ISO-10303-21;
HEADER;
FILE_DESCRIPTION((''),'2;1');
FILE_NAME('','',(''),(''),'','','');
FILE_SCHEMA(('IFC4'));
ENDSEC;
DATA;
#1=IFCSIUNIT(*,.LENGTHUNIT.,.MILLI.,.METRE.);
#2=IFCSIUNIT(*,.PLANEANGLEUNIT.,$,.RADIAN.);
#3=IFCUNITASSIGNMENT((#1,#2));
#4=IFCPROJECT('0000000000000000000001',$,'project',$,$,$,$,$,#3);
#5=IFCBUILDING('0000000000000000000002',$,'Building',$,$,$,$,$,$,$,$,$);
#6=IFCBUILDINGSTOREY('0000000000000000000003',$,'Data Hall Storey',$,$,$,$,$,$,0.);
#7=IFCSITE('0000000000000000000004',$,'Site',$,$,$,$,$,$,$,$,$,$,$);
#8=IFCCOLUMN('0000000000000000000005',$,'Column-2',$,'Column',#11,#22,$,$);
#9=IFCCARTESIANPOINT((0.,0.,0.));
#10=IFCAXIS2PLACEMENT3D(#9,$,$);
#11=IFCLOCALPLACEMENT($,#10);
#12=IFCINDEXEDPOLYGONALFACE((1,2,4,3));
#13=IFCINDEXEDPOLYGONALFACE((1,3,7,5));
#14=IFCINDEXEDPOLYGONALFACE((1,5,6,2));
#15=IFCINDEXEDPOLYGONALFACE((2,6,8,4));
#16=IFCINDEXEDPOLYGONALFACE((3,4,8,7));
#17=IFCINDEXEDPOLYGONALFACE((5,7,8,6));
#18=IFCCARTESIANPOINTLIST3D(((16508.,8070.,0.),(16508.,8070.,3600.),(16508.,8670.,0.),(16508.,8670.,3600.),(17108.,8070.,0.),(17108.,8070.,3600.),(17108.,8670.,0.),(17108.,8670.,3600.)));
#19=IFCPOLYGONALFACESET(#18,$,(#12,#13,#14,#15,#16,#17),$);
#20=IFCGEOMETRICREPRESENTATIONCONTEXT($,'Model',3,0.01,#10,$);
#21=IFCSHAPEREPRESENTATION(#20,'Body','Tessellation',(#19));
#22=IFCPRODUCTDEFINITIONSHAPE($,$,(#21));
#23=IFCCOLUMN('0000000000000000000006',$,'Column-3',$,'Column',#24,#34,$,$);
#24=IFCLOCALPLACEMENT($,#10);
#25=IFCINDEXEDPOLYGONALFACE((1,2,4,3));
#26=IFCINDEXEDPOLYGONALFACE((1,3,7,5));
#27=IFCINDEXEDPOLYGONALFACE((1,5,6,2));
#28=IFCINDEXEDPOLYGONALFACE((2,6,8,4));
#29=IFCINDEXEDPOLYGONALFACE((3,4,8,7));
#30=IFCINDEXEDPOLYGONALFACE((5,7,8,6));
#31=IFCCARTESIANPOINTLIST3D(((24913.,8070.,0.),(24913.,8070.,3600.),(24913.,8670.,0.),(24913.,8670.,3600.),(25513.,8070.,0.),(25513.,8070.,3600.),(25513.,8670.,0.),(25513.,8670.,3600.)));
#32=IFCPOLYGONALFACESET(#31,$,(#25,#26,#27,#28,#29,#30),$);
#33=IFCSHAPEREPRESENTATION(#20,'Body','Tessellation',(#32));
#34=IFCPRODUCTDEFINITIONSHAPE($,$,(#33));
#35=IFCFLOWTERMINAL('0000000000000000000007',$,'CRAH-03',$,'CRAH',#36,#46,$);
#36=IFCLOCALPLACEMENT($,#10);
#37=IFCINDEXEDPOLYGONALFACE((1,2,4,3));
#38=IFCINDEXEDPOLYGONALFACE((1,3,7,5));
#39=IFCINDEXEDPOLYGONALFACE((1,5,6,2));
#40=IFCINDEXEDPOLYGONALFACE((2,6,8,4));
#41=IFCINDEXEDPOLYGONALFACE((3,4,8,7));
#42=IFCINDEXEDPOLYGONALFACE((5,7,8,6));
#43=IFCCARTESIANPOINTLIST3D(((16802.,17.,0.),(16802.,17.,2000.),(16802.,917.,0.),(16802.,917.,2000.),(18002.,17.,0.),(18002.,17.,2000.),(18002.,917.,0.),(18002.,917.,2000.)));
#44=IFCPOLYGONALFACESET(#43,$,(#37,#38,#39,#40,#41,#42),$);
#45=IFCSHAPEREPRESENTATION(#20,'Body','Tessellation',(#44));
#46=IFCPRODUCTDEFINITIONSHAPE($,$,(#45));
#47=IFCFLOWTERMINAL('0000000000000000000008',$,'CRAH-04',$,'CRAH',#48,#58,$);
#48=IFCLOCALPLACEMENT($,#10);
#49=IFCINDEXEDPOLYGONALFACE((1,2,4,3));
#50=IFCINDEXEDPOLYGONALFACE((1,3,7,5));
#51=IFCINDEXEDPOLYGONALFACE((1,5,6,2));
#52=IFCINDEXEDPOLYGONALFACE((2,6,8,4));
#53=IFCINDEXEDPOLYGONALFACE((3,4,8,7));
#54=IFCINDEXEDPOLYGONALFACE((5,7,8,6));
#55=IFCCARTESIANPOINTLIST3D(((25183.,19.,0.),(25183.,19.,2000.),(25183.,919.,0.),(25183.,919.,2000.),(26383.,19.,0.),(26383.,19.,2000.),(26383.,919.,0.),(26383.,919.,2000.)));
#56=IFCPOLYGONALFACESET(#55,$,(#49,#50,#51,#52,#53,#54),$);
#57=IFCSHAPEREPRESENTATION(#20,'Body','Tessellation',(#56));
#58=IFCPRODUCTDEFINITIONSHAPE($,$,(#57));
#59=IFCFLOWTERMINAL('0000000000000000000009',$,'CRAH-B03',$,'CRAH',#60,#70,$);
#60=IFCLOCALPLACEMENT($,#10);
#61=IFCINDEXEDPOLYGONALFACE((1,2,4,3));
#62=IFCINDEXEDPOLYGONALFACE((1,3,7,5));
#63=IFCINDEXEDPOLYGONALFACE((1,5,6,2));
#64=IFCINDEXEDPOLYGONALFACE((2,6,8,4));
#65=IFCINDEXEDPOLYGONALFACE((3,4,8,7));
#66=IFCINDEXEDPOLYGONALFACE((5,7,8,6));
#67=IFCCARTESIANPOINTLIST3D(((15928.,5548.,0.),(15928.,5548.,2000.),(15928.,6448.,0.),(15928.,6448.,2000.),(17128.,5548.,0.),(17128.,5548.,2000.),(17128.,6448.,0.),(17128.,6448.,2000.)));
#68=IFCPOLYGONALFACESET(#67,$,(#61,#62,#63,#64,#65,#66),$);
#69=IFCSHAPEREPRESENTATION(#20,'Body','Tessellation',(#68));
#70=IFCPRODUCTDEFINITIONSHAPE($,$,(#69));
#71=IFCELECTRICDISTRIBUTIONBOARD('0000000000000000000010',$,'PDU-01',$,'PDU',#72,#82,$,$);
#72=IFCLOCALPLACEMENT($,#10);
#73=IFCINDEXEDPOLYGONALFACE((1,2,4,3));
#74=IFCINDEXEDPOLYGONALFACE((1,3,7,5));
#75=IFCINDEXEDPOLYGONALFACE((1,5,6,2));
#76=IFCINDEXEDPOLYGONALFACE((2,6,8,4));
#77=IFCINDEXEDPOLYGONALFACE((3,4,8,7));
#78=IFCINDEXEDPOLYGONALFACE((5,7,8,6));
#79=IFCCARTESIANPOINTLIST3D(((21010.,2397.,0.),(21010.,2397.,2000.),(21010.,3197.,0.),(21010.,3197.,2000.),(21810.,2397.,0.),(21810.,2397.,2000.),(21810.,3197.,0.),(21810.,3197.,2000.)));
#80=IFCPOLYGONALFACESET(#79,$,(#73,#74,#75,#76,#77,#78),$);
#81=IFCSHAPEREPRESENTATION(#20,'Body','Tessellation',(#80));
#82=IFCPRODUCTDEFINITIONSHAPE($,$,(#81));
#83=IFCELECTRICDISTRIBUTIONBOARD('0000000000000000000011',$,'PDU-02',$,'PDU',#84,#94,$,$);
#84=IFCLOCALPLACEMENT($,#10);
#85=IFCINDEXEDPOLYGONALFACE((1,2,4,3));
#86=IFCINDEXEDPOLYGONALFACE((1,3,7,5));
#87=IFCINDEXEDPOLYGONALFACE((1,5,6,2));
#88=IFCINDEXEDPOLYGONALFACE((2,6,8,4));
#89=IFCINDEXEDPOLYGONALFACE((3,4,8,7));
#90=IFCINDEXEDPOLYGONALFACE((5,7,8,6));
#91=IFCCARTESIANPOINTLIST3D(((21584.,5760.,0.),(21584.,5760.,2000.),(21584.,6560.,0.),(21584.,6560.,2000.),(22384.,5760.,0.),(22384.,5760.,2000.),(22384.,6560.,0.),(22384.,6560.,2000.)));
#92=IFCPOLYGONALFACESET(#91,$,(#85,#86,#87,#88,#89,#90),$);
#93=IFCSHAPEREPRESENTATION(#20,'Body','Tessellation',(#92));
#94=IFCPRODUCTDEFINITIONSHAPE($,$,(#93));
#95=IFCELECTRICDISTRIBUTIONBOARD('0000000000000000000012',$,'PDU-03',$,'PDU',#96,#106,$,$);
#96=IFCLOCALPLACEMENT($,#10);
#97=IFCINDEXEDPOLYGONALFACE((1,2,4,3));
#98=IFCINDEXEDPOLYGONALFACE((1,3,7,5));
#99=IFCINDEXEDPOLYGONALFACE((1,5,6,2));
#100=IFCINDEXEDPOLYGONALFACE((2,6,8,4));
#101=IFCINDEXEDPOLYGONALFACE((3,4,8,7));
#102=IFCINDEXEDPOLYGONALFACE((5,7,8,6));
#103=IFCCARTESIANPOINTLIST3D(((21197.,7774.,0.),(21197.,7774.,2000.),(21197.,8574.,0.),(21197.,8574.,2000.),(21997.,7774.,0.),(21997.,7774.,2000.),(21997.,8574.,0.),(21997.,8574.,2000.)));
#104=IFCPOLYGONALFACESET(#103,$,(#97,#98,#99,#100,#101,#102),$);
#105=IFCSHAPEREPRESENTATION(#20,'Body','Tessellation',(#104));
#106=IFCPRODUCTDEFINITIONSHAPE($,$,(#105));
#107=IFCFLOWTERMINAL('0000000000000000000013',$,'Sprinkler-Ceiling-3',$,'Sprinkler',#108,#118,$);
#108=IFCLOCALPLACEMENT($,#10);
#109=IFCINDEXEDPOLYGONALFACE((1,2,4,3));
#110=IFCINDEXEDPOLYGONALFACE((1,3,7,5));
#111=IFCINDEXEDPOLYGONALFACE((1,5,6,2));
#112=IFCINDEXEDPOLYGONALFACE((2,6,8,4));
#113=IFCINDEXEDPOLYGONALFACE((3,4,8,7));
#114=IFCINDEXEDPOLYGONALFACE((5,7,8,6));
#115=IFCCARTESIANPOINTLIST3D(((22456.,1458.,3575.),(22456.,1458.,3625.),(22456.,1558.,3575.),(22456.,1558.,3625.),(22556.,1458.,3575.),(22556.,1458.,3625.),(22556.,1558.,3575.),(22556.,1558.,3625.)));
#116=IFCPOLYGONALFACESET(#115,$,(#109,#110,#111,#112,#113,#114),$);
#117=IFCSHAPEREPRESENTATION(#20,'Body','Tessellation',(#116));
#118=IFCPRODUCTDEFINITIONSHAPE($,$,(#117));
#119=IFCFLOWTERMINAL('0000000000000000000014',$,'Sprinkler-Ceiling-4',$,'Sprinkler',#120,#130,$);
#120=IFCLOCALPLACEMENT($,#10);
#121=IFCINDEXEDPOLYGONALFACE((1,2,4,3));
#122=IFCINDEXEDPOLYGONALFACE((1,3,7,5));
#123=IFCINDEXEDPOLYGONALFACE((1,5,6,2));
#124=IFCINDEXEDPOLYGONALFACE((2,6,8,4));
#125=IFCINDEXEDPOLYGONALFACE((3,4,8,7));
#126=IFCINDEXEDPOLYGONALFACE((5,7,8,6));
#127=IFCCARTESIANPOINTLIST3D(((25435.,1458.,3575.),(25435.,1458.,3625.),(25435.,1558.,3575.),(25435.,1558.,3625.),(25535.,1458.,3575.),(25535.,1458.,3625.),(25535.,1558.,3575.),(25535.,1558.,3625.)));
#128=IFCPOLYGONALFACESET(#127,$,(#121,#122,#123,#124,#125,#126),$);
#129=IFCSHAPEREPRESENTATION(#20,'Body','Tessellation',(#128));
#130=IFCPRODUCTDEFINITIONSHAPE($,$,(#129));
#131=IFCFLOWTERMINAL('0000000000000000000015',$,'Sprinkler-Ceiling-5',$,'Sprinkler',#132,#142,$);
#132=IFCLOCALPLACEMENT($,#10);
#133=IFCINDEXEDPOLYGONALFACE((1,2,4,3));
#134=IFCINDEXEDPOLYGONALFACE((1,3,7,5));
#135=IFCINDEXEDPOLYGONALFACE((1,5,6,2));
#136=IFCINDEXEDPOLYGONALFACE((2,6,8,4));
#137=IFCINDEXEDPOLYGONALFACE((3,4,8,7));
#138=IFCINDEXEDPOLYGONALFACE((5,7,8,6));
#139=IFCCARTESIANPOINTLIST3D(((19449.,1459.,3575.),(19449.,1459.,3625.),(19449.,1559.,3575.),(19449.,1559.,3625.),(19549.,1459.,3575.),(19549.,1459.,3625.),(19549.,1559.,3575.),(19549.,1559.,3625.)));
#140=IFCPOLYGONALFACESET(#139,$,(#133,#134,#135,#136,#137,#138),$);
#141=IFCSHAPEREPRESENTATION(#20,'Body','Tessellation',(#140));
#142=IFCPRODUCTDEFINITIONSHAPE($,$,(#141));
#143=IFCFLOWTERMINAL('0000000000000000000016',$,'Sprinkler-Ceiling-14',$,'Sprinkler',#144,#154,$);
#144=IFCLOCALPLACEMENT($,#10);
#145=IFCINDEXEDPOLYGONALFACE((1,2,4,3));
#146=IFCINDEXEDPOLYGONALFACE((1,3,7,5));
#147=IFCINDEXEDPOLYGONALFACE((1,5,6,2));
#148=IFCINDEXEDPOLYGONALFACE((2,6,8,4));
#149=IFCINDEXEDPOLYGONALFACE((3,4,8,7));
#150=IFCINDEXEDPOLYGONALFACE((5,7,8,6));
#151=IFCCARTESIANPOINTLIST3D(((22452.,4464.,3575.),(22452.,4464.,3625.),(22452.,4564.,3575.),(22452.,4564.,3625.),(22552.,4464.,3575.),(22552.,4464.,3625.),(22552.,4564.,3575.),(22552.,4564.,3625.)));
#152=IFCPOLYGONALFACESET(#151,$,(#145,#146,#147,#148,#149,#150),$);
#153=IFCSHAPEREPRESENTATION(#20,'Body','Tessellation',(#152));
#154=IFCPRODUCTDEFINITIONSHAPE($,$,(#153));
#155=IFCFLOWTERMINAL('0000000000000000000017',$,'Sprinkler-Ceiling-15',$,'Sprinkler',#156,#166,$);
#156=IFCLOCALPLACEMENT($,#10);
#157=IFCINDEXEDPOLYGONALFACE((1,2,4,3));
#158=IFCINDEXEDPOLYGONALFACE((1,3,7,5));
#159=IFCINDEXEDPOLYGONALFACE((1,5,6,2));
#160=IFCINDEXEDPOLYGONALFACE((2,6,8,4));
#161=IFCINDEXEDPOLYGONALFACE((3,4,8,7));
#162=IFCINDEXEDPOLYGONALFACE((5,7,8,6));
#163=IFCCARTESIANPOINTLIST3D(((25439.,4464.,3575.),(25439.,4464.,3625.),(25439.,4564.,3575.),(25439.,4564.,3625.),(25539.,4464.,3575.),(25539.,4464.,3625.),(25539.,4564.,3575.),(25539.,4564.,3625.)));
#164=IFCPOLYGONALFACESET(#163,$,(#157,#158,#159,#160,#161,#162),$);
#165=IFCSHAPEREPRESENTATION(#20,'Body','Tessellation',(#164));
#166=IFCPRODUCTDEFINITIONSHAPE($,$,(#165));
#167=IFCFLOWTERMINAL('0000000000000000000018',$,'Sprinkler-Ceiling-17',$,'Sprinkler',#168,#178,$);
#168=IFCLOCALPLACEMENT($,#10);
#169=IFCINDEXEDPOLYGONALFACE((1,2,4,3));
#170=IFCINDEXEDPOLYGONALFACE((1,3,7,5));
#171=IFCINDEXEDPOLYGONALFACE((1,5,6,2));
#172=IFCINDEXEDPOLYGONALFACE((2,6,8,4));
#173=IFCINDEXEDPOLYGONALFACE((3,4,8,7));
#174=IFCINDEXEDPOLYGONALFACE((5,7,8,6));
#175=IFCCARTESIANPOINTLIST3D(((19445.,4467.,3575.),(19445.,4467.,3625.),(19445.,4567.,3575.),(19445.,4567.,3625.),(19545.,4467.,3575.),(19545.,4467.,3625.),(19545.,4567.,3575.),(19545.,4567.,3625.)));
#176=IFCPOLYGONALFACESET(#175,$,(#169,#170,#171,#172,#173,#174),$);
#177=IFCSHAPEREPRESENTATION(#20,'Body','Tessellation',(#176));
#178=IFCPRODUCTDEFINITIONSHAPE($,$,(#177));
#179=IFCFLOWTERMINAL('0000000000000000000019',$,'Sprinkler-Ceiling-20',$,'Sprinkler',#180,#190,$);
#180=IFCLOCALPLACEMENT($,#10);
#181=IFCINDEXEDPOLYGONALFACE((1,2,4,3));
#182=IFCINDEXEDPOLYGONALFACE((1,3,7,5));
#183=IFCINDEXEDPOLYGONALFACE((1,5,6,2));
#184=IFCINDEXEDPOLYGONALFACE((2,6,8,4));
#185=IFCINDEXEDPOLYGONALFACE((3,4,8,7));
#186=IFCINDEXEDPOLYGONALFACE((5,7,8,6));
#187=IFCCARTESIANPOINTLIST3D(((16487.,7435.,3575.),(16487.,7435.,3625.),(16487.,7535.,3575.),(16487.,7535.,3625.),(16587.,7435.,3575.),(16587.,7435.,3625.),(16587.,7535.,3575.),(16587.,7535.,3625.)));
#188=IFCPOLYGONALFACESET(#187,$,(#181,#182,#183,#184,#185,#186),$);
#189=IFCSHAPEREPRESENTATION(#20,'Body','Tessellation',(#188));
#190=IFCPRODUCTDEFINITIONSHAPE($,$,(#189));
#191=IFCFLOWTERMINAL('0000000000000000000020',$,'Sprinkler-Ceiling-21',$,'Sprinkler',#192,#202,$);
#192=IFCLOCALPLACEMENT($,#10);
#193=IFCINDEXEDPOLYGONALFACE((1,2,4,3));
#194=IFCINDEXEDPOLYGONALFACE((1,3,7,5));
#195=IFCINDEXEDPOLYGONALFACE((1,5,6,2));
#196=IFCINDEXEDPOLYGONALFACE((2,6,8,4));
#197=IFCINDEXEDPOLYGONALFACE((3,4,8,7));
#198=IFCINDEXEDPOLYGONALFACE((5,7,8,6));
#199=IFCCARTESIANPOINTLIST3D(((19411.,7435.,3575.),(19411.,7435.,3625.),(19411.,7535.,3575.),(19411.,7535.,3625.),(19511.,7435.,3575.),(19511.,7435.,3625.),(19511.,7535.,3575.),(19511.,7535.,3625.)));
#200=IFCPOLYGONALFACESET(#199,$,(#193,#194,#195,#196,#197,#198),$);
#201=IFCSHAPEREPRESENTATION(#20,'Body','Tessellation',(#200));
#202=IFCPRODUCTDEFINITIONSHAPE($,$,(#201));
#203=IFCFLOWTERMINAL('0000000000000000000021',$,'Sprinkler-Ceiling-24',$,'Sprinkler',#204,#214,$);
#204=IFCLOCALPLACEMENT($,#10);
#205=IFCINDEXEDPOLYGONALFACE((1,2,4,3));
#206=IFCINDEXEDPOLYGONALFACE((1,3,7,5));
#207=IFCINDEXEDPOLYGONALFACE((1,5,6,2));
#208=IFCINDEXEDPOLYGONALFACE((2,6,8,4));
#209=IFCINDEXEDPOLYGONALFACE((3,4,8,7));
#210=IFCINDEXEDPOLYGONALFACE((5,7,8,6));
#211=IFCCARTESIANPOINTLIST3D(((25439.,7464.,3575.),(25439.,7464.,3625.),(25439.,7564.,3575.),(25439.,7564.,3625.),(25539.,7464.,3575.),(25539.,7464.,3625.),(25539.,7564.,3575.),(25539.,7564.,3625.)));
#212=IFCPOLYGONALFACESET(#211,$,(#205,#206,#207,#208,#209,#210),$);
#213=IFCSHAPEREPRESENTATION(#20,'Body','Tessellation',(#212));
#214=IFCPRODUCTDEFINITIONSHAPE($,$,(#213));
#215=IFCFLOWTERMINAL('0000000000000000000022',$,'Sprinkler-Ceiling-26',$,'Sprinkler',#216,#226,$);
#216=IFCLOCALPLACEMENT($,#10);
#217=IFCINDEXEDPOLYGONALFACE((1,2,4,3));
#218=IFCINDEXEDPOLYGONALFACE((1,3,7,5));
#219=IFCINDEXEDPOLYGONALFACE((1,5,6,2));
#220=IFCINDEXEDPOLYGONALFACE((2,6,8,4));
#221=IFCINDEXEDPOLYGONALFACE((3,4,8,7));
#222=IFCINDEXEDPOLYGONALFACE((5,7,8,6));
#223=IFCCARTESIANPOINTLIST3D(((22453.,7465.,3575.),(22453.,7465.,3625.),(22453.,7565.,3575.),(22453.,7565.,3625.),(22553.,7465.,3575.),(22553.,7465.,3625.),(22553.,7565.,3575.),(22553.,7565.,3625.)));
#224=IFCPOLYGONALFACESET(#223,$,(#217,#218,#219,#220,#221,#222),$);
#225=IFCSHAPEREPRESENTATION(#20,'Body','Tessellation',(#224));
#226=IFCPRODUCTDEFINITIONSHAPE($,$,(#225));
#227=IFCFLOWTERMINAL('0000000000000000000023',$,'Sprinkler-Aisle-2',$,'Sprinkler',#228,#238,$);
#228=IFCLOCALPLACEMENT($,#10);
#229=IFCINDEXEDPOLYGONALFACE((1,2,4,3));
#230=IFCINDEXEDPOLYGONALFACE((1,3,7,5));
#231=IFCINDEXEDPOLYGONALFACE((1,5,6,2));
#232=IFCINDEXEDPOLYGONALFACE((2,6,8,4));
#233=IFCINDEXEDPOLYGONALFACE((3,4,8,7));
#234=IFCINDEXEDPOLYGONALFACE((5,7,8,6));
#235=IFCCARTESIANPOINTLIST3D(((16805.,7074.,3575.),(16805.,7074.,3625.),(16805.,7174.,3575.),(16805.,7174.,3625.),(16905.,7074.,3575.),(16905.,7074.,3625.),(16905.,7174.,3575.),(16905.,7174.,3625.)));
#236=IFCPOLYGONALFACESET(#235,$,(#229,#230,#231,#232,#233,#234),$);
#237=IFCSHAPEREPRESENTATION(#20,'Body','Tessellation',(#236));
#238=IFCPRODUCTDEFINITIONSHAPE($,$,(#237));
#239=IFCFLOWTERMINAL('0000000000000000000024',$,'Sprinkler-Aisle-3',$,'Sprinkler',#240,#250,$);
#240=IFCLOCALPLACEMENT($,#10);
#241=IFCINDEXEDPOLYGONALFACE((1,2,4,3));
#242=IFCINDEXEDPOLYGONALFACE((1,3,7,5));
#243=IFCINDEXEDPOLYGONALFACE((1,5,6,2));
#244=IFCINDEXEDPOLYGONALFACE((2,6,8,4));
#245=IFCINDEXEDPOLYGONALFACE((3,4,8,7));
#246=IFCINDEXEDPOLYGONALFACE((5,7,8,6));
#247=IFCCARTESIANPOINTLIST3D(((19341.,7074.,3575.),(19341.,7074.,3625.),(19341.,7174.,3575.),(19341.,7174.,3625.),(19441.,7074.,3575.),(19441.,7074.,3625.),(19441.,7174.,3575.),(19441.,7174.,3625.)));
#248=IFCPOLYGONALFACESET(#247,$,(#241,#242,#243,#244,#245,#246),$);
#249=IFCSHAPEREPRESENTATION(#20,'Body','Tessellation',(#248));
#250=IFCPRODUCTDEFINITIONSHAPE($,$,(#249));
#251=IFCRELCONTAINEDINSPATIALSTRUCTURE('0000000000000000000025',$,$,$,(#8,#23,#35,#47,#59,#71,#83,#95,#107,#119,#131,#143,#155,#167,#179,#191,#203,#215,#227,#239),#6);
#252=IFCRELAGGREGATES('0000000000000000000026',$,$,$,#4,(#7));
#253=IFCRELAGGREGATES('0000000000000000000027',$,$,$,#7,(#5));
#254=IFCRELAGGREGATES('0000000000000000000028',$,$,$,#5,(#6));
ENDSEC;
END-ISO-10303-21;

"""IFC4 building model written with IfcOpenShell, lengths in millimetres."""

from ifc_helpers import new_model, si_unit, frame, origin, place, context, project, spatial, rectangle, extrude, element, save


model = new_model("IFC4")

# Units and contexts
model_context = context("Model", 3, precision=0.01, world=origin())
ifc_project = project(units=[si_unit("LENGTHUNIT", "METRE", prefix="MILLI"), si_unit("PLANEANGLEUNIT", "RADIAN")])

# Site, building, storey
site = spatial("IfcSite", under=ifc_project, Name="Site")
building = spatial("IfcBuilding", under=site, Name="Building")
storey = spatial("IfcBuildingStorey", under=building, Name="Data Hall Storey", Elevation=0.0)

# Columns
for number, where, name in (
    (1, (16808.0, 8370.0, 0.0), "Column-2"),
    (2, (25213.0, 8370.0, 0.0), "Column-3"),
):
    element("IfcColumn", number, at=place(None, frame(where)), inside=storey, Name=name, ObjectType="Column", context=model_context, shape_type="SweptSolid", body=[
        extrude(rectangle(XDim=600.0, YDim=600.0), origin(), (0.0, 0.0, 1.0), 3600.0),
    ])

# Flow terminals
for number, where, name in (
    (3, (17402.0, 467.0, 0.0), "CRAH-03"),
    (4, (25783.0, 469.0, 0.0), "CRAH-04"),
    (5, (16528.0, 5998.0, 0.0), "CRAH-B03"),
):
    element("IfcFlowTerminal", number, at=place(None, frame(where)), inside=storey, Name=name, ObjectType="CRAH", context=model_context, shape_type="SweptSolid", body=[
        extrude(rectangle(XDim=1200.0, YDim=900.0), origin(), (0.0, 0.0, 1.0), 2000.0),
    ])

# Electric distribution boards
for number, where, name in (
    (6, (21410.0, 2797.0, 0.0), "PDU-01"),
    (7, (21984.0, 6160.0, 0.0), "PDU-02"),
    (8, (21597.0, 8174.0, 0.0), "PDU-03"),
):
    element("IfcElectricDistributionBoard", number, at=place(None, frame(where)), inside=storey, Name=name, ObjectType="PDU", context=model_context, shape_type="SweptSolid", body=[
        extrude(rectangle(XDim=800.0, YDim=800.0), origin(), (0.0, 0.0, 1.0), 2000.0),
    ])

# Flow terminals
for number, where, name in (
    (9, (22506.0, 1508.0, 3575.0), "Sprinkler-Ceiling-3"),
    (10, (25485.0, 1508.0, 3575.0), "Sprinkler-Ceiling-4"),
    (11, (19499.0, 1509.0, 3575.0), "Sprinkler-Ceiling-5"),
    (12, (22502.0, 4514.0, 3575.0), "Sprinkler-Ceiling-14"),
    (13, (25489.0, 4514.0, 3575.0), "Sprinkler-Ceiling-15"),
    (14, (19495.0, 4517.0, 3575.0), "Sprinkler-Ceiling-17"),
    (15, (16537.0, 7485.0, 3575.0), "Sprinkler-Ceiling-20"),
    (16, (19461.0, 7485.0, 3575.0), "Sprinkler-Ceiling-21"),
    (17, (25489.0, 7514.0, 3575.0), "Sprinkler-Ceiling-24"),
    (18, (22503.0, 7515.0, 3575.0), "Sprinkler-Ceiling-26"),
    (19, (16855.0, 7124.0, 3575.0), "Sprinkler-Aisle-2"),
    (20, (19391.0, 7124.0, 3575.0), "Sprinkler-Aisle-3"),
):
    element("IfcFlowTerminal", number, at=place(None, frame(where)), inside=storey, Name=name, ObjectType="Sprinkler", context=model_context, shape_type="SweptSolid", body=[
        extrude(rectangle(XDim=100.0, YDim=100.0), origin(), (0.0, 0.0, 1.0), 50.0),
    ])

save(model, "model.ifc")
